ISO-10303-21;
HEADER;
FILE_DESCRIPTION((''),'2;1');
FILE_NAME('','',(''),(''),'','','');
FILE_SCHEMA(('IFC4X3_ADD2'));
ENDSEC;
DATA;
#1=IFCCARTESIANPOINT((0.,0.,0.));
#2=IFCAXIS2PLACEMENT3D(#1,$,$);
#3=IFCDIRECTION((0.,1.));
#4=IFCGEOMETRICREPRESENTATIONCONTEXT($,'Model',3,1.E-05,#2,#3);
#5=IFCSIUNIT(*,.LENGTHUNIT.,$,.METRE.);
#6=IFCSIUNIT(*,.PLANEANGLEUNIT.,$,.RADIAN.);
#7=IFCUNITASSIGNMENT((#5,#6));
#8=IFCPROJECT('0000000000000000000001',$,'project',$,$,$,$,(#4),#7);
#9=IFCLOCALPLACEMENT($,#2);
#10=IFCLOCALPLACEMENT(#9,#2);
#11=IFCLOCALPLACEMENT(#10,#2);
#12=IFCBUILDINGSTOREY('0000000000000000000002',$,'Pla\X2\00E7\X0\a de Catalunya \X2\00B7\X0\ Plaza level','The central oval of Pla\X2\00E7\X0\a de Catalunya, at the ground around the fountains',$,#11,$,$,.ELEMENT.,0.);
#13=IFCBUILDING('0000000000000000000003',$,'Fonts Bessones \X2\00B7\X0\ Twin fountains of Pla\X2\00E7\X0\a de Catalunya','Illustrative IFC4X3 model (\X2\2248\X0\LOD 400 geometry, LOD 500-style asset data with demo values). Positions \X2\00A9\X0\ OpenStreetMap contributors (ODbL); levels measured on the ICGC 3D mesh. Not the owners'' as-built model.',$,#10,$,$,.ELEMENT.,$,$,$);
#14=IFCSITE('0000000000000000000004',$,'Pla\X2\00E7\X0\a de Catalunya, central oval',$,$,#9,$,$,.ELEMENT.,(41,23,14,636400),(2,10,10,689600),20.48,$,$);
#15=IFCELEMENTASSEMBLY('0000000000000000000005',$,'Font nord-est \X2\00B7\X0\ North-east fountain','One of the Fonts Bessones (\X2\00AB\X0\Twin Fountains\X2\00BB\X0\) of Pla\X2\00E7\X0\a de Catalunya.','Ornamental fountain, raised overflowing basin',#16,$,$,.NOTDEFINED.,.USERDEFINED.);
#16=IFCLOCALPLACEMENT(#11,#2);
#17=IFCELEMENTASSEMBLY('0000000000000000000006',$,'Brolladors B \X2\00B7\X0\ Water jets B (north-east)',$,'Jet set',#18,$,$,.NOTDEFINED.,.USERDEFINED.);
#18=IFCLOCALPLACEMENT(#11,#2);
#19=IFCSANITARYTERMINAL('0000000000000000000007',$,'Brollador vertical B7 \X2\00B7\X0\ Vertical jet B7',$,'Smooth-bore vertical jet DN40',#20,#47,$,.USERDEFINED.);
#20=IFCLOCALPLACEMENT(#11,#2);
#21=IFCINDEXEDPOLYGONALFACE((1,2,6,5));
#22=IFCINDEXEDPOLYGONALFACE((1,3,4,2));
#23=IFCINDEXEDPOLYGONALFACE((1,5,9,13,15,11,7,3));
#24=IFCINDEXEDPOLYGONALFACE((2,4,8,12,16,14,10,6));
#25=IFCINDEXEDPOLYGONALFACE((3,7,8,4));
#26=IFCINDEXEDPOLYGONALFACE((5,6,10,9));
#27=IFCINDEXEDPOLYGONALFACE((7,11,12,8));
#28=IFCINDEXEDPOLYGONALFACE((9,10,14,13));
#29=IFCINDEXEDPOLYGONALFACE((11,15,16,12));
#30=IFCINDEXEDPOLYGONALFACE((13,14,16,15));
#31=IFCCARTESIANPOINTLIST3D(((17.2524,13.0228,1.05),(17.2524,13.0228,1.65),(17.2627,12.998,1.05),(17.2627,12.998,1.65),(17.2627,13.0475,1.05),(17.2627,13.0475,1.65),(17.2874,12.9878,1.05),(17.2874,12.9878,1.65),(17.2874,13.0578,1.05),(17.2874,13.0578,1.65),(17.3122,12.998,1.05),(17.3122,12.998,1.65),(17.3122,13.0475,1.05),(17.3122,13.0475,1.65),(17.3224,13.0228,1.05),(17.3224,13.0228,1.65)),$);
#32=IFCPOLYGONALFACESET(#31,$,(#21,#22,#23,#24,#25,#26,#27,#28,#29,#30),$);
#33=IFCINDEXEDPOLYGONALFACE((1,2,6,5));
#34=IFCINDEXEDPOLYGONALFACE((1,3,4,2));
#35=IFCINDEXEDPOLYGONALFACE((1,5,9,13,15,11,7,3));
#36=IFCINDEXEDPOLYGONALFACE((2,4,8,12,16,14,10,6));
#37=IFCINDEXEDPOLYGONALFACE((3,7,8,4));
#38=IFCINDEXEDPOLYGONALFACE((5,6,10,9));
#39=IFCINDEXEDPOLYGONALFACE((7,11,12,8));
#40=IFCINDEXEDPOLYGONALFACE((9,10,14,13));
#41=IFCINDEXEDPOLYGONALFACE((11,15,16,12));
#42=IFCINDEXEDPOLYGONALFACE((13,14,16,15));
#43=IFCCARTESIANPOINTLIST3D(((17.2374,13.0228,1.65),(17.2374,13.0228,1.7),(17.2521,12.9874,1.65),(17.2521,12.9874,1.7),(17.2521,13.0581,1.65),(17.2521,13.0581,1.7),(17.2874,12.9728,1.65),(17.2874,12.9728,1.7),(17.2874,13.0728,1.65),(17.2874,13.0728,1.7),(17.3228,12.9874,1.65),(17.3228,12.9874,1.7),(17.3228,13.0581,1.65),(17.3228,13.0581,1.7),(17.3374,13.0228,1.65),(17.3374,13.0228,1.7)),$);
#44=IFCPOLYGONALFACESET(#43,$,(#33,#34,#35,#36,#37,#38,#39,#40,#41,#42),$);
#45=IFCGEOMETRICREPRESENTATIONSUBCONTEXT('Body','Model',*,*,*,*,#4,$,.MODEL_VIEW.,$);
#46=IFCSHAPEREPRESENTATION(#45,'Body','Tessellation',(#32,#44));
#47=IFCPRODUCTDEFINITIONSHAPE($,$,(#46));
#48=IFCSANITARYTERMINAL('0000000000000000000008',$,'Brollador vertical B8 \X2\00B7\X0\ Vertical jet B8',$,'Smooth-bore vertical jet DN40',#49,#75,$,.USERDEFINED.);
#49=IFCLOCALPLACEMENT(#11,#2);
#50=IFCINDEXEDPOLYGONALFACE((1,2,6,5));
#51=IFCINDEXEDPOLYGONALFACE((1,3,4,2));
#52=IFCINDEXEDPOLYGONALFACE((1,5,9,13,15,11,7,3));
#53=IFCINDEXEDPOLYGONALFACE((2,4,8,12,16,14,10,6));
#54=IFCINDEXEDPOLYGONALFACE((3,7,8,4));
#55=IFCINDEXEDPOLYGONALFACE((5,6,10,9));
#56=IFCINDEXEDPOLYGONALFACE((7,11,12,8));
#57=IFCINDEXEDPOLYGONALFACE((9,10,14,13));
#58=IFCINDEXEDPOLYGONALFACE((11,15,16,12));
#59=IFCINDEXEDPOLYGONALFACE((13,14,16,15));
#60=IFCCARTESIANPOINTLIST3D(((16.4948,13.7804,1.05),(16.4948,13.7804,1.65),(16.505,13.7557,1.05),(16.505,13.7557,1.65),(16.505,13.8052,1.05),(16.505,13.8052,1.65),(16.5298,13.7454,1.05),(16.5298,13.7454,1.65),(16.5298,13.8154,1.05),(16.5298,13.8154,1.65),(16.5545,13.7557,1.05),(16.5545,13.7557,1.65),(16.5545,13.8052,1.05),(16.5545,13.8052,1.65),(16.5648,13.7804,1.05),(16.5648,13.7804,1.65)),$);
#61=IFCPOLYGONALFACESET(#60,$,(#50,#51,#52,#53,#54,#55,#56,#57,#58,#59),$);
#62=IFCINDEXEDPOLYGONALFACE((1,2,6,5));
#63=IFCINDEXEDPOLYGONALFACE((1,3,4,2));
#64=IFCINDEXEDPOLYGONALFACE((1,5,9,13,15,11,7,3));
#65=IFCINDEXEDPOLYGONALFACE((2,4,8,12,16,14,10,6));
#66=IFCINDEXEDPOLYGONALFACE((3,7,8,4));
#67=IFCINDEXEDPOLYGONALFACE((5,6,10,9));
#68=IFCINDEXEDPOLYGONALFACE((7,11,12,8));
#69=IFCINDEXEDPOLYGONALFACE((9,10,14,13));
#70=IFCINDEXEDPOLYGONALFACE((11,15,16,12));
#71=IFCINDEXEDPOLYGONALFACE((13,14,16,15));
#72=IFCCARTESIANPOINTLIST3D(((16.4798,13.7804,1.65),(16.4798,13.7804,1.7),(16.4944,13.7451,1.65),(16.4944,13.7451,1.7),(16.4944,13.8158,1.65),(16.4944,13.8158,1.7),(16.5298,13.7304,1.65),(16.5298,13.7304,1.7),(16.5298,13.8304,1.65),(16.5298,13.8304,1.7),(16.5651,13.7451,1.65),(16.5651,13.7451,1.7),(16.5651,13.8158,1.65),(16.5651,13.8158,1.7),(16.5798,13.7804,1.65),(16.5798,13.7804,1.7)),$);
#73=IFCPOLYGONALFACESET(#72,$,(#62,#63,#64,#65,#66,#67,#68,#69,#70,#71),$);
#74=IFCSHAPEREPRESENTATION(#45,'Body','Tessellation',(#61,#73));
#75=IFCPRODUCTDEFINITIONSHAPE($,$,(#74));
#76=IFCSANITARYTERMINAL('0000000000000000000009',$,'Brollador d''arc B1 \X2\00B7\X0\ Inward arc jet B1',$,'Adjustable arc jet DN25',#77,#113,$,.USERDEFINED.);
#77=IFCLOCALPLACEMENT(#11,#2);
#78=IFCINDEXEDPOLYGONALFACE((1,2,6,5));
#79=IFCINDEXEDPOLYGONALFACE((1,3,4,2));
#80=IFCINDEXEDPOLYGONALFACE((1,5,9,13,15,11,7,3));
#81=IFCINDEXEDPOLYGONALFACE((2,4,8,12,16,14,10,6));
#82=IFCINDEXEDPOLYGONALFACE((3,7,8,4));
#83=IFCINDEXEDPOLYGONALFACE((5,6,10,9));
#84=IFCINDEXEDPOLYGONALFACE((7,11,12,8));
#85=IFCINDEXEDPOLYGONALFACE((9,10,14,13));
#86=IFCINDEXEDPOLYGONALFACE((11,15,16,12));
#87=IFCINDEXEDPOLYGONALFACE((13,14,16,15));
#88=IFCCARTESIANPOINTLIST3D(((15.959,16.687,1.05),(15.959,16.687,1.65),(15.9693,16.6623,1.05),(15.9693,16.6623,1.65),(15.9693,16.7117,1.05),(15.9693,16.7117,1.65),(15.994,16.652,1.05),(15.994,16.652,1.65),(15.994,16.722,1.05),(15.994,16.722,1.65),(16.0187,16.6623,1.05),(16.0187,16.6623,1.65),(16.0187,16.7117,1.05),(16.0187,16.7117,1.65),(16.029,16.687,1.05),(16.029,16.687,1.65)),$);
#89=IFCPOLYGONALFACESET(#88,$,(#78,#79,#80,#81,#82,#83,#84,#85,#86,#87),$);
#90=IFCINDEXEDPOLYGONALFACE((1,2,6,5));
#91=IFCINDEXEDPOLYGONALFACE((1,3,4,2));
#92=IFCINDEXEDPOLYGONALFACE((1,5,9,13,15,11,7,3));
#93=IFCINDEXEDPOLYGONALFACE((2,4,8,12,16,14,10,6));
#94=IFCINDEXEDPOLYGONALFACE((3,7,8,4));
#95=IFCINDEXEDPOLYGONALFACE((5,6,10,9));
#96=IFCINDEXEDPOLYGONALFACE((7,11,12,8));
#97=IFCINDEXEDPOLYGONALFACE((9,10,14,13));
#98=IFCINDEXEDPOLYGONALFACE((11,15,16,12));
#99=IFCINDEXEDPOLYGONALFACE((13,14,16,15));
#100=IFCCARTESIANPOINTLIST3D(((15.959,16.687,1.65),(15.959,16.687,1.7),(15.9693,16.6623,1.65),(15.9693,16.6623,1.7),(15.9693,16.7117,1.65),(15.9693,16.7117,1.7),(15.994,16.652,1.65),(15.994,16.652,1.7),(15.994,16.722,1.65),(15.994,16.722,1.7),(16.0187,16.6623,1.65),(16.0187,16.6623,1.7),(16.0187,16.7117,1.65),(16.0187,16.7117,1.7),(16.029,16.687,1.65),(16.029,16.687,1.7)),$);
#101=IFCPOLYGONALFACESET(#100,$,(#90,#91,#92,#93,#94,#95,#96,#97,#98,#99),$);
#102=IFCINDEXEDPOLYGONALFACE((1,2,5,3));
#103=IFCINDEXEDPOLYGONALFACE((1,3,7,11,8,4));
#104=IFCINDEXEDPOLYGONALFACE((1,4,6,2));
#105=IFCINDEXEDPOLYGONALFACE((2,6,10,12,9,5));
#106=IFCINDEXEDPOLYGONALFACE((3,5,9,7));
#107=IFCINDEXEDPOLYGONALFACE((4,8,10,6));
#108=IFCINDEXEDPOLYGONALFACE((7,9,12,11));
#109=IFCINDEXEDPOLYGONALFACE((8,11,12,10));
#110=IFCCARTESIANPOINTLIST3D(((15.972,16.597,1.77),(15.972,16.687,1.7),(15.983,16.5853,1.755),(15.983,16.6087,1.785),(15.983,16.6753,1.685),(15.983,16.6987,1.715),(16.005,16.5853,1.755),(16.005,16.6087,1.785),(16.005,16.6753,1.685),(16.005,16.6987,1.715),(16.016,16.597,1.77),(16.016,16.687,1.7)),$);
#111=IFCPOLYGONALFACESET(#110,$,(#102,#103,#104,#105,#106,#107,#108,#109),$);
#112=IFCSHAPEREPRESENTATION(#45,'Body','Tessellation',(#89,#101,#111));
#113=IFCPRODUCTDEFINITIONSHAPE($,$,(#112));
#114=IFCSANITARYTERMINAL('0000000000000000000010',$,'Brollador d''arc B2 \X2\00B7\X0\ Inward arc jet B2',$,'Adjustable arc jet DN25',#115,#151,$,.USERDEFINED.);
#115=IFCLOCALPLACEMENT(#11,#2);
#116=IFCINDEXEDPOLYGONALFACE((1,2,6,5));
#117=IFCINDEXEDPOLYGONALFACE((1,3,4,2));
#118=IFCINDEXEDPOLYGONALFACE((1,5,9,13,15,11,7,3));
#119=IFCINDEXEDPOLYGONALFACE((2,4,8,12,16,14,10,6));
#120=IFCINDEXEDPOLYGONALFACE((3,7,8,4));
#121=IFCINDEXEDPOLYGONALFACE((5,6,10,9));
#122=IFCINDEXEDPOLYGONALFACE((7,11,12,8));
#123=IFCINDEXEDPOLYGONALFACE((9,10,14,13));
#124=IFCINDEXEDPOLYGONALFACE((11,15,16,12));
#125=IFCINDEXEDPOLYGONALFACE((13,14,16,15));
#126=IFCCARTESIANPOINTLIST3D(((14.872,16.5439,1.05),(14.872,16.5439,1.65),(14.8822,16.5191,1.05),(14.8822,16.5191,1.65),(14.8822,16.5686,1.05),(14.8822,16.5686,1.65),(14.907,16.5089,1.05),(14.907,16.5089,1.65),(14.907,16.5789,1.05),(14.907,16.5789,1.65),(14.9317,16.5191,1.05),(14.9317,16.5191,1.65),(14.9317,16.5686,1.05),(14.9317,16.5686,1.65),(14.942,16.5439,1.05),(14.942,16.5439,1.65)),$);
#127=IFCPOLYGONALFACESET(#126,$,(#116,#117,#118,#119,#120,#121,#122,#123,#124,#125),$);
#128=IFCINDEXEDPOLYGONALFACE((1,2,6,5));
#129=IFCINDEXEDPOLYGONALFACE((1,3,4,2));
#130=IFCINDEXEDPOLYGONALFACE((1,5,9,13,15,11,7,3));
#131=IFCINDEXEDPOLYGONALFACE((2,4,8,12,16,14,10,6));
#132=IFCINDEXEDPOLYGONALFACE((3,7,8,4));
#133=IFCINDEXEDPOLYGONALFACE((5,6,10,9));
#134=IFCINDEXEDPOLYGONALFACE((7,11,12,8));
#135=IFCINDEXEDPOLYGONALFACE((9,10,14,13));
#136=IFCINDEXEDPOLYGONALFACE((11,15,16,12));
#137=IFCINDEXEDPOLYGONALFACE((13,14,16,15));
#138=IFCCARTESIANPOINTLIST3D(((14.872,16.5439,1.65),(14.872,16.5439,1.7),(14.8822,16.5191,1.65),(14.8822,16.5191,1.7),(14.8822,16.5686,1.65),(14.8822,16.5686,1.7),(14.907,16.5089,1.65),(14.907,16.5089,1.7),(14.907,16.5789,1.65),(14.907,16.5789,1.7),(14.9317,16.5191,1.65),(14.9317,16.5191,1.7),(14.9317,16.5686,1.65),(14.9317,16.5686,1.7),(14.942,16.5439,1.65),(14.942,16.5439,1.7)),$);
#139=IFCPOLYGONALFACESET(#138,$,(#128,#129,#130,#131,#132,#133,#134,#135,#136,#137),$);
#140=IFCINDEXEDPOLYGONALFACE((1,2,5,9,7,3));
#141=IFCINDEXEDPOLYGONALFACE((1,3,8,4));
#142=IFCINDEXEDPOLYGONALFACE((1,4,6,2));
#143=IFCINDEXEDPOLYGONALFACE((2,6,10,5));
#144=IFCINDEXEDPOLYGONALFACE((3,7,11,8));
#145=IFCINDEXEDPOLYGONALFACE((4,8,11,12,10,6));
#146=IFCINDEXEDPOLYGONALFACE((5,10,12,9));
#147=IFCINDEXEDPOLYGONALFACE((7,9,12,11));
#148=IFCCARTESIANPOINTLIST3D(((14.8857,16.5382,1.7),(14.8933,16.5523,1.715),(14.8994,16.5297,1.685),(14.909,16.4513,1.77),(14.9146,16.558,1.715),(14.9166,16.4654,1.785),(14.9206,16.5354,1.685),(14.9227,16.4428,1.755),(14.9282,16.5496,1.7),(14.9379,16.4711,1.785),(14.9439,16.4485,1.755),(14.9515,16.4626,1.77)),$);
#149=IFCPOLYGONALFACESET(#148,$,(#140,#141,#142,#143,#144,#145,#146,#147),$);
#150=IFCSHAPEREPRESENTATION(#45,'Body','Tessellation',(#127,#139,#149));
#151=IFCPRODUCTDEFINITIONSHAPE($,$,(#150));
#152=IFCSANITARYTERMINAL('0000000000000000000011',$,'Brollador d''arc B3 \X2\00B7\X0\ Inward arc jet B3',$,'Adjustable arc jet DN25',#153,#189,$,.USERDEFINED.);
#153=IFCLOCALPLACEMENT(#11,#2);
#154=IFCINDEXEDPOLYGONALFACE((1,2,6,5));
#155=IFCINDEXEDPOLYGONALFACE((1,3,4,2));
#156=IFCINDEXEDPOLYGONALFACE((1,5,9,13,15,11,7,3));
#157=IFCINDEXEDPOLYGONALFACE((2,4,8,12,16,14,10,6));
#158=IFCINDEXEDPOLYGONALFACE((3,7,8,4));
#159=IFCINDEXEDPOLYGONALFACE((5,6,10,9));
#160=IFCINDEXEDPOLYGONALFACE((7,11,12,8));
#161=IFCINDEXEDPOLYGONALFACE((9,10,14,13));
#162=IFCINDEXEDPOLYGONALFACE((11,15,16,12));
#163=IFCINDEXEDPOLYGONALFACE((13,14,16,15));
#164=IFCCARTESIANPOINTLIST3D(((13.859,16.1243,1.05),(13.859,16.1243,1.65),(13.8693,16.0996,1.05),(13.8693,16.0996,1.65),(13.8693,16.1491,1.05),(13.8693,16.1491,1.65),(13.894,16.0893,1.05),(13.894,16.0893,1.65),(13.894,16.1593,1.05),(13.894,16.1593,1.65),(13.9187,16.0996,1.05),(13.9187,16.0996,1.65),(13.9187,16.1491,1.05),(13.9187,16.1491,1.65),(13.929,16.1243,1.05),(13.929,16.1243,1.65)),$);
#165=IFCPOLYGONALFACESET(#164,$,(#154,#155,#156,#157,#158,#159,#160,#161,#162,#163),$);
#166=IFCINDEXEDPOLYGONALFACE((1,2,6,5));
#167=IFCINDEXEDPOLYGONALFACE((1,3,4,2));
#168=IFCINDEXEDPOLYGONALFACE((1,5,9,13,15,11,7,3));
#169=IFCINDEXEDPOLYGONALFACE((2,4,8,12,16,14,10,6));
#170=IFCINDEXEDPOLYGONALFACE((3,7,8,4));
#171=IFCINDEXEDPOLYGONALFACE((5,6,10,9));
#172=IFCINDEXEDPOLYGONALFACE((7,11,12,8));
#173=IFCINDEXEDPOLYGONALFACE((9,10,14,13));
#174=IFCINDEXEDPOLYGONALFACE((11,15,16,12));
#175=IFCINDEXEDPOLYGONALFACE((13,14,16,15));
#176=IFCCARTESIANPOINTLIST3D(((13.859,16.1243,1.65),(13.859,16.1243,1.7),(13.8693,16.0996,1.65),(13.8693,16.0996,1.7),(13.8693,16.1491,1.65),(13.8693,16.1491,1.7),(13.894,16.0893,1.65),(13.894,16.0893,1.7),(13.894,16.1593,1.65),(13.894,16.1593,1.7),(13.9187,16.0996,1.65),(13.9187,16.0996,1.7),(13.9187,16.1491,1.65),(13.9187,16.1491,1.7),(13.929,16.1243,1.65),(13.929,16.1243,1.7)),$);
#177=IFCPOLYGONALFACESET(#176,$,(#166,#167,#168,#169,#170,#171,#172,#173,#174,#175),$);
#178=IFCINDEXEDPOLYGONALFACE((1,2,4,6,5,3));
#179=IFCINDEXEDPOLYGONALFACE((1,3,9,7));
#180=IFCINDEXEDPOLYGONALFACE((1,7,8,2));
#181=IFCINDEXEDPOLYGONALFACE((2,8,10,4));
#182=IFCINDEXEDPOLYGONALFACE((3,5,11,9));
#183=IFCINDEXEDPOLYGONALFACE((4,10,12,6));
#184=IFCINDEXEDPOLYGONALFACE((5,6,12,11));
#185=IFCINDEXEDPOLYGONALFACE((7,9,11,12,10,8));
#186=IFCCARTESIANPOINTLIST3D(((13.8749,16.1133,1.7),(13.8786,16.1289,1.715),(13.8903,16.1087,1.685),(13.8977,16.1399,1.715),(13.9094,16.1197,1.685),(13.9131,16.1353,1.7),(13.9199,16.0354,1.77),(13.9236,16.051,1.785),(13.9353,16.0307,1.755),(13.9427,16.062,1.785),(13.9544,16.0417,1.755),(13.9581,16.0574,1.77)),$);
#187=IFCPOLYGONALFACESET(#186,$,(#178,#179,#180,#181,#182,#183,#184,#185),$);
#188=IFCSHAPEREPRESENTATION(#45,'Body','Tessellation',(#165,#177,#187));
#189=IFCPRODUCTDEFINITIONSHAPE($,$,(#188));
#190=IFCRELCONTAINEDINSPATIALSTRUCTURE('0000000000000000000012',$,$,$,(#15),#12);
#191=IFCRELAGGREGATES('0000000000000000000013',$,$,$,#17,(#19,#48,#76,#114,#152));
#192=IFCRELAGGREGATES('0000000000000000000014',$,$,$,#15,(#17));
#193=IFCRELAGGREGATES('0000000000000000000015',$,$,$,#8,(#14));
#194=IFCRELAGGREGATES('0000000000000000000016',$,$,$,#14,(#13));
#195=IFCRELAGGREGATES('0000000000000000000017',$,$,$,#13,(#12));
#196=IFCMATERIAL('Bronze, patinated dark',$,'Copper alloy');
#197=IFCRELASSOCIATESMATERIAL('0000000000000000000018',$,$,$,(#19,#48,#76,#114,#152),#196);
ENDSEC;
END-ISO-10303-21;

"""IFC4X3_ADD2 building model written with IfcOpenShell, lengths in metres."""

from ifc_helpers import new_model, si_unit, direction, frame, origin, place, context, subcontext, project, spatial, polyline, outline, extrude, material, element, aggregate, save


model = new_model("IFC4X3_ADD2")

# Units and contexts
model_context = context("Model", 3, precision=1e-05, world=origin(), true_north=direction((0.0, 1.0)))
body_context = subcontext(model_context, "Body", "Model", "MODEL_VIEW")
ifc_project = project(units=[si_unit("LENGTHUNIT", "METRE"), si_unit("PLANEANGLEUNIT", "RADIAN")], contexts=[model_context])

# Site, building, storey
site_placement = place(None, origin())
site = spatial("IfcSite", under=ifc_project, at=site_placement, Name="Plaça de Catalunya, central oval", CompositionType="ELEMENT", RefLatitude=(41, 23, 14, 636400), RefLongitude=(2, 10, 10, 689600), RefElevation=20.48)
building_placement = place(site_placement, origin())
building = spatial("IfcBuilding", under=site, at=building_placement, Name="Fonts Bessones · Twin fountains of Plaça de Catalunya", Description="Illustrative IFC4X3 model (≈LOD 400 geometry, LOD 500-style asset data with demo values). Positions © OpenStreetMap contributors (ODbL); levels measured on the ICGC 3D mesh. Not the owners' as-built model.", CompositionType="ELEMENT")
storey_placement = place(building_placement, origin())
storey = spatial("IfcBuildingStorey", under=building, at=storey_placement, Name="Plaça de Catalunya · Plaza level", Description="The central oval of Plaça de Catalunya, at the ground around the fountains", CompositionType="ELEMENT", Elevation=0.0)

# Element assemblies, sanitary terminals
assembly_1_placement = place(building_placement, origin())
assembly_1 = element("IfcElementAssembly", 1, at=assembly_1_placement, inside=storey, Name="Font nord-est · North-east fountain", Description="One of the Fonts Bessones («Twin Fountains») of Plaça de Catalunya.", ObjectType="Ornamental fountain, raised overflowing basin", AssemblyPlace="NOTDEFINED", PredefinedType="USERDEFINED")
assembly_2_placement = place(building_placement, origin())
assembly_2 = element("IfcElementAssembly", 2, at=assembly_2_placement, Name="Brolladors B · Water jets B (north-east)", ObjectType="Jet set", AssemblyPlace="NOTDEFINED", PredefinedType="USERDEFINED")
ifc_material_1 = material(Name="Bronze, patinated dark", Category="Copper alloy")
sanitary_terminal_1_placement = place(building_placement, origin())
sanitary_terminal_1 = element("IfcSanitaryTerminal", 3, at=sanitary_terminal_1_placement, material=ifc_material_1, Name="Brollador vertical B7 · Vertical jet B7", ObjectType="Smooth-bore vertical jet DN40", PredefinedType="USERDEFINED", context=body_context, shape_type="SweptSolid", body=[
    extrude(outline(polyline([(17.3224, 13.0228), (17.3122, 13.0475), (17.2874, 13.0578), (17.2627, 13.0475), (17.2524, 13.0228), (17.2627, 12.998), (17.2874, 12.9878), (17.3122, 12.998), (17.3224, 13.0228)])), frame((0.0, 0.0, 1.05)), (0.0, 0.0, 1.0), 0.6),
    extrude(outline(polyline([(17.3374, 13.0228), (17.3228, 13.0581), (17.2874, 13.0728), (17.2521, 13.0581), (17.2374, 13.0228), (17.2521, 12.9874), (17.2874, 12.9728), (17.3228, 12.9874), (17.3374, 13.0228)])), frame((0.0, 0.0, 1.65)), (0.0, 0.0, 1.0), 0.05),
])
sanitary_terminal_2_placement = place(building_placement, origin())
sanitary_terminal_2 = element("IfcSanitaryTerminal", 4, at=sanitary_terminal_2_placement, material=ifc_material_1, Name="Brollador vertical B8 · Vertical jet B8", ObjectType="Smooth-bore vertical jet DN40", PredefinedType="USERDEFINED", context=body_context, shape_type="SweptSolid", body=[
    extrude(outline(polyline([(16.5648, 13.7804), (16.5545, 13.8052), (16.5298, 13.8154), (16.505, 13.8052), (16.4948, 13.7804), (16.505, 13.7557), (16.5298, 13.7454), (16.5545, 13.7557), (16.5648, 13.7804)])), frame((0.0, 0.0, 1.05)), (0.0, 0.0, 1.0), 0.6),
    extrude(outline(polyline([(16.5798, 13.7804), (16.5651, 13.8158), (16.5298, 13.8304), (16.4944, 13.8158), (16.4798, 13.7804), (16.4944, 13.7451), (16.5298, 13.7304), (16.5651, 13.7451), (16.5798, 13.7804)])), frame((0.0, 0.0, 1.65)), (0.0, 0.0, 1.0), 0.05),
])
sanitary_terminal_3_placement = place(building_placement, origin())
sanitary_terminal_3 = element("IfcSanitaryTerminal", 5, at=sanitary_terminal_3_placement, material=ifc_material_1, Name="Brollador d'arc B1 · Inward arc jet B1", ObjectType="Adjustable arc jet DN25", PredefinedType="USERDEFINED", context=body_context, shape_type="SweptSolid", body=[
    extrude(outline(polyline([(16.029, 16.687), (16.0187, 16.7117), (15.994, 16.722), (15.9693, 16.7117), (15.959, 16.687), (15.9693, 16.6623), (15.994, 16.652), (16.0187, 16.6623), (16.029, 16.687)])), frame((0.0, 0.0, 1.05)), (0.0, 0.0, 1.0), 0.6),
    extrude(outline(polyline([(16.029, 16.687), (16.0187, 16.7117), (15.994, 16.722), (15.9693, 16.7117), (15.959, 16.687), (15.9693, 16.6623), (15.994, 16.652), (16.0187, 16.6623), (16.029, 16.687)])), frame((0.0, 0.0, 1.65)), (0.0, 0.0, 1.0), 0.05),
    extrude(outline(polyline([(0.022, 0.0), (0.011, 0.0191), (-0.011, 0.0191), (-0.022, 0.0), (-0.011, -0.0191), (0.011, -0.0191), (0.022, 0.0)])), frame((15.994, 16.687, 1.7), z_axis=(0.0, -0.789352, 0.613941), x_axis=(-1.0, 0.0, 0.0)), (0.0, 0.0, 1.0), 0.114),
])
sanitary_terminal_4_placement = place(building_placement, origin())
sanitary_terminal_4 = element("IfcSanitaryTerminal", 6, at=sanitary_terminal_4_placement, material=ifc_material_1, Name="Brollador d'arc B2 · Inward arc jet B2", ObjectType="Adjustable arc jet DN25", PredefinedType="USERDEFINED", context=body_context, shape_type="SweptSolid", body=[
    extrude(outline(polyline([(14.942, 16.5439), (14.9317, 16.5686), (14.907, 16.5789), (14.8822, 16.5686), (14.872, 16.5439), (14.8822, 16.5191), (14.907, 16.5089), (14.9317, 16.5191), (14.942, 16.5439)])), frame((0.0, 0.0, 1.05)), (0.0, 0.0, 1.0), 0.6),
    extrude(outline(polyline([(14.942, 16.5439), (14.9317, 16.5686), (14.907, 16.5789), (14.8822, 16.5686), (14.872, 16.5439), (14.8822, 16.5191), (14.907, 16.5089), (14.9317, 16.5191), (14.942, 16.5439)])), frame((0.0, 0.0, 1.65)), (0.0, 0.0, 1.0), 0.05),
    extrude(outline(polyline([(0.022, 0.0), (0.011, 0.0191), (-0.011, 0.0191), (-0.022, 0.0), (-0.011, -0.0191), (0.011, -0.0191), (0.022, 0.0)])), frame((14.907, 16.5439, 1.7), z_axis=(0.204299, -0.762456, 0.613941), x_axis=(-0.965926, -0.258819, 0.0)), (0.0, 0.0, 1.0), 0.114),
])
sanitary_terminal_5_placement = place(building_placement, origin())
sanitary_terminal_5 = element("IfcSanitaryTerminal", 7, at=sanitary_terminal_5_placement, material=ifc_material_1, Name="Brollador d'arc B3 · Inward arc jet B3", ObjectType="Adjustable arc jet DN25", PredefinedType="USERDEFINED", context=body_context, shape_type="SweptSolid", body=[
    extrude(outline(polyline([(13.929, 16.1243), (13.9187, 16.1491), (13.894, 16.1593), (13.8693, 16.1491), (13.859, 16.1243), (13.8693, 16.0996), (13.894, 16.0893), (13.9187, 16.0996), (13.929, 16.1243)])), frame((0.0, 0.0, 1.05)), (0.0, 0.0, 1.0), 0.6),
    extrude(outline(polyline([(13.929, 16.1243), (13.9187, 16.1491), (13.894, 16.1593), (13.8693, 16.1491), (13.859, 16.1243), (13.8693, 16.0996), (13.894, 16.0893), (13.9187, 16.0996), (13.929, 16.1243)])), frame((0.0, 0.0, 1.65)), (0.0, 0.0, 1.0), 0.05),
    extrude(outline(polyline([(0.022, 0.0), (0.011, 0.0191), (-0.011, 0.0191), (-0.022, 0.0), (-0.011, -0.0191), (0.011, -0.0191), (0.022, 0.0)])), frame((13.894, 16.1243, 1.7), z_axis=(0.394676, -0.683599, 0.613941), x_axis=(-0.866025, -0.5, 0.0)), (0.0, 0.0, 1.0), 0.114),
])
aggregate(assembly_2, [sanitary_terminal_1, sanitary_terminal_2, sanitary_terminal_3, sanitary_terminal_4, sanitary_terminal_5])
aggregate(assembly_1, [assembly_2])

save(model, "model.ifc")
